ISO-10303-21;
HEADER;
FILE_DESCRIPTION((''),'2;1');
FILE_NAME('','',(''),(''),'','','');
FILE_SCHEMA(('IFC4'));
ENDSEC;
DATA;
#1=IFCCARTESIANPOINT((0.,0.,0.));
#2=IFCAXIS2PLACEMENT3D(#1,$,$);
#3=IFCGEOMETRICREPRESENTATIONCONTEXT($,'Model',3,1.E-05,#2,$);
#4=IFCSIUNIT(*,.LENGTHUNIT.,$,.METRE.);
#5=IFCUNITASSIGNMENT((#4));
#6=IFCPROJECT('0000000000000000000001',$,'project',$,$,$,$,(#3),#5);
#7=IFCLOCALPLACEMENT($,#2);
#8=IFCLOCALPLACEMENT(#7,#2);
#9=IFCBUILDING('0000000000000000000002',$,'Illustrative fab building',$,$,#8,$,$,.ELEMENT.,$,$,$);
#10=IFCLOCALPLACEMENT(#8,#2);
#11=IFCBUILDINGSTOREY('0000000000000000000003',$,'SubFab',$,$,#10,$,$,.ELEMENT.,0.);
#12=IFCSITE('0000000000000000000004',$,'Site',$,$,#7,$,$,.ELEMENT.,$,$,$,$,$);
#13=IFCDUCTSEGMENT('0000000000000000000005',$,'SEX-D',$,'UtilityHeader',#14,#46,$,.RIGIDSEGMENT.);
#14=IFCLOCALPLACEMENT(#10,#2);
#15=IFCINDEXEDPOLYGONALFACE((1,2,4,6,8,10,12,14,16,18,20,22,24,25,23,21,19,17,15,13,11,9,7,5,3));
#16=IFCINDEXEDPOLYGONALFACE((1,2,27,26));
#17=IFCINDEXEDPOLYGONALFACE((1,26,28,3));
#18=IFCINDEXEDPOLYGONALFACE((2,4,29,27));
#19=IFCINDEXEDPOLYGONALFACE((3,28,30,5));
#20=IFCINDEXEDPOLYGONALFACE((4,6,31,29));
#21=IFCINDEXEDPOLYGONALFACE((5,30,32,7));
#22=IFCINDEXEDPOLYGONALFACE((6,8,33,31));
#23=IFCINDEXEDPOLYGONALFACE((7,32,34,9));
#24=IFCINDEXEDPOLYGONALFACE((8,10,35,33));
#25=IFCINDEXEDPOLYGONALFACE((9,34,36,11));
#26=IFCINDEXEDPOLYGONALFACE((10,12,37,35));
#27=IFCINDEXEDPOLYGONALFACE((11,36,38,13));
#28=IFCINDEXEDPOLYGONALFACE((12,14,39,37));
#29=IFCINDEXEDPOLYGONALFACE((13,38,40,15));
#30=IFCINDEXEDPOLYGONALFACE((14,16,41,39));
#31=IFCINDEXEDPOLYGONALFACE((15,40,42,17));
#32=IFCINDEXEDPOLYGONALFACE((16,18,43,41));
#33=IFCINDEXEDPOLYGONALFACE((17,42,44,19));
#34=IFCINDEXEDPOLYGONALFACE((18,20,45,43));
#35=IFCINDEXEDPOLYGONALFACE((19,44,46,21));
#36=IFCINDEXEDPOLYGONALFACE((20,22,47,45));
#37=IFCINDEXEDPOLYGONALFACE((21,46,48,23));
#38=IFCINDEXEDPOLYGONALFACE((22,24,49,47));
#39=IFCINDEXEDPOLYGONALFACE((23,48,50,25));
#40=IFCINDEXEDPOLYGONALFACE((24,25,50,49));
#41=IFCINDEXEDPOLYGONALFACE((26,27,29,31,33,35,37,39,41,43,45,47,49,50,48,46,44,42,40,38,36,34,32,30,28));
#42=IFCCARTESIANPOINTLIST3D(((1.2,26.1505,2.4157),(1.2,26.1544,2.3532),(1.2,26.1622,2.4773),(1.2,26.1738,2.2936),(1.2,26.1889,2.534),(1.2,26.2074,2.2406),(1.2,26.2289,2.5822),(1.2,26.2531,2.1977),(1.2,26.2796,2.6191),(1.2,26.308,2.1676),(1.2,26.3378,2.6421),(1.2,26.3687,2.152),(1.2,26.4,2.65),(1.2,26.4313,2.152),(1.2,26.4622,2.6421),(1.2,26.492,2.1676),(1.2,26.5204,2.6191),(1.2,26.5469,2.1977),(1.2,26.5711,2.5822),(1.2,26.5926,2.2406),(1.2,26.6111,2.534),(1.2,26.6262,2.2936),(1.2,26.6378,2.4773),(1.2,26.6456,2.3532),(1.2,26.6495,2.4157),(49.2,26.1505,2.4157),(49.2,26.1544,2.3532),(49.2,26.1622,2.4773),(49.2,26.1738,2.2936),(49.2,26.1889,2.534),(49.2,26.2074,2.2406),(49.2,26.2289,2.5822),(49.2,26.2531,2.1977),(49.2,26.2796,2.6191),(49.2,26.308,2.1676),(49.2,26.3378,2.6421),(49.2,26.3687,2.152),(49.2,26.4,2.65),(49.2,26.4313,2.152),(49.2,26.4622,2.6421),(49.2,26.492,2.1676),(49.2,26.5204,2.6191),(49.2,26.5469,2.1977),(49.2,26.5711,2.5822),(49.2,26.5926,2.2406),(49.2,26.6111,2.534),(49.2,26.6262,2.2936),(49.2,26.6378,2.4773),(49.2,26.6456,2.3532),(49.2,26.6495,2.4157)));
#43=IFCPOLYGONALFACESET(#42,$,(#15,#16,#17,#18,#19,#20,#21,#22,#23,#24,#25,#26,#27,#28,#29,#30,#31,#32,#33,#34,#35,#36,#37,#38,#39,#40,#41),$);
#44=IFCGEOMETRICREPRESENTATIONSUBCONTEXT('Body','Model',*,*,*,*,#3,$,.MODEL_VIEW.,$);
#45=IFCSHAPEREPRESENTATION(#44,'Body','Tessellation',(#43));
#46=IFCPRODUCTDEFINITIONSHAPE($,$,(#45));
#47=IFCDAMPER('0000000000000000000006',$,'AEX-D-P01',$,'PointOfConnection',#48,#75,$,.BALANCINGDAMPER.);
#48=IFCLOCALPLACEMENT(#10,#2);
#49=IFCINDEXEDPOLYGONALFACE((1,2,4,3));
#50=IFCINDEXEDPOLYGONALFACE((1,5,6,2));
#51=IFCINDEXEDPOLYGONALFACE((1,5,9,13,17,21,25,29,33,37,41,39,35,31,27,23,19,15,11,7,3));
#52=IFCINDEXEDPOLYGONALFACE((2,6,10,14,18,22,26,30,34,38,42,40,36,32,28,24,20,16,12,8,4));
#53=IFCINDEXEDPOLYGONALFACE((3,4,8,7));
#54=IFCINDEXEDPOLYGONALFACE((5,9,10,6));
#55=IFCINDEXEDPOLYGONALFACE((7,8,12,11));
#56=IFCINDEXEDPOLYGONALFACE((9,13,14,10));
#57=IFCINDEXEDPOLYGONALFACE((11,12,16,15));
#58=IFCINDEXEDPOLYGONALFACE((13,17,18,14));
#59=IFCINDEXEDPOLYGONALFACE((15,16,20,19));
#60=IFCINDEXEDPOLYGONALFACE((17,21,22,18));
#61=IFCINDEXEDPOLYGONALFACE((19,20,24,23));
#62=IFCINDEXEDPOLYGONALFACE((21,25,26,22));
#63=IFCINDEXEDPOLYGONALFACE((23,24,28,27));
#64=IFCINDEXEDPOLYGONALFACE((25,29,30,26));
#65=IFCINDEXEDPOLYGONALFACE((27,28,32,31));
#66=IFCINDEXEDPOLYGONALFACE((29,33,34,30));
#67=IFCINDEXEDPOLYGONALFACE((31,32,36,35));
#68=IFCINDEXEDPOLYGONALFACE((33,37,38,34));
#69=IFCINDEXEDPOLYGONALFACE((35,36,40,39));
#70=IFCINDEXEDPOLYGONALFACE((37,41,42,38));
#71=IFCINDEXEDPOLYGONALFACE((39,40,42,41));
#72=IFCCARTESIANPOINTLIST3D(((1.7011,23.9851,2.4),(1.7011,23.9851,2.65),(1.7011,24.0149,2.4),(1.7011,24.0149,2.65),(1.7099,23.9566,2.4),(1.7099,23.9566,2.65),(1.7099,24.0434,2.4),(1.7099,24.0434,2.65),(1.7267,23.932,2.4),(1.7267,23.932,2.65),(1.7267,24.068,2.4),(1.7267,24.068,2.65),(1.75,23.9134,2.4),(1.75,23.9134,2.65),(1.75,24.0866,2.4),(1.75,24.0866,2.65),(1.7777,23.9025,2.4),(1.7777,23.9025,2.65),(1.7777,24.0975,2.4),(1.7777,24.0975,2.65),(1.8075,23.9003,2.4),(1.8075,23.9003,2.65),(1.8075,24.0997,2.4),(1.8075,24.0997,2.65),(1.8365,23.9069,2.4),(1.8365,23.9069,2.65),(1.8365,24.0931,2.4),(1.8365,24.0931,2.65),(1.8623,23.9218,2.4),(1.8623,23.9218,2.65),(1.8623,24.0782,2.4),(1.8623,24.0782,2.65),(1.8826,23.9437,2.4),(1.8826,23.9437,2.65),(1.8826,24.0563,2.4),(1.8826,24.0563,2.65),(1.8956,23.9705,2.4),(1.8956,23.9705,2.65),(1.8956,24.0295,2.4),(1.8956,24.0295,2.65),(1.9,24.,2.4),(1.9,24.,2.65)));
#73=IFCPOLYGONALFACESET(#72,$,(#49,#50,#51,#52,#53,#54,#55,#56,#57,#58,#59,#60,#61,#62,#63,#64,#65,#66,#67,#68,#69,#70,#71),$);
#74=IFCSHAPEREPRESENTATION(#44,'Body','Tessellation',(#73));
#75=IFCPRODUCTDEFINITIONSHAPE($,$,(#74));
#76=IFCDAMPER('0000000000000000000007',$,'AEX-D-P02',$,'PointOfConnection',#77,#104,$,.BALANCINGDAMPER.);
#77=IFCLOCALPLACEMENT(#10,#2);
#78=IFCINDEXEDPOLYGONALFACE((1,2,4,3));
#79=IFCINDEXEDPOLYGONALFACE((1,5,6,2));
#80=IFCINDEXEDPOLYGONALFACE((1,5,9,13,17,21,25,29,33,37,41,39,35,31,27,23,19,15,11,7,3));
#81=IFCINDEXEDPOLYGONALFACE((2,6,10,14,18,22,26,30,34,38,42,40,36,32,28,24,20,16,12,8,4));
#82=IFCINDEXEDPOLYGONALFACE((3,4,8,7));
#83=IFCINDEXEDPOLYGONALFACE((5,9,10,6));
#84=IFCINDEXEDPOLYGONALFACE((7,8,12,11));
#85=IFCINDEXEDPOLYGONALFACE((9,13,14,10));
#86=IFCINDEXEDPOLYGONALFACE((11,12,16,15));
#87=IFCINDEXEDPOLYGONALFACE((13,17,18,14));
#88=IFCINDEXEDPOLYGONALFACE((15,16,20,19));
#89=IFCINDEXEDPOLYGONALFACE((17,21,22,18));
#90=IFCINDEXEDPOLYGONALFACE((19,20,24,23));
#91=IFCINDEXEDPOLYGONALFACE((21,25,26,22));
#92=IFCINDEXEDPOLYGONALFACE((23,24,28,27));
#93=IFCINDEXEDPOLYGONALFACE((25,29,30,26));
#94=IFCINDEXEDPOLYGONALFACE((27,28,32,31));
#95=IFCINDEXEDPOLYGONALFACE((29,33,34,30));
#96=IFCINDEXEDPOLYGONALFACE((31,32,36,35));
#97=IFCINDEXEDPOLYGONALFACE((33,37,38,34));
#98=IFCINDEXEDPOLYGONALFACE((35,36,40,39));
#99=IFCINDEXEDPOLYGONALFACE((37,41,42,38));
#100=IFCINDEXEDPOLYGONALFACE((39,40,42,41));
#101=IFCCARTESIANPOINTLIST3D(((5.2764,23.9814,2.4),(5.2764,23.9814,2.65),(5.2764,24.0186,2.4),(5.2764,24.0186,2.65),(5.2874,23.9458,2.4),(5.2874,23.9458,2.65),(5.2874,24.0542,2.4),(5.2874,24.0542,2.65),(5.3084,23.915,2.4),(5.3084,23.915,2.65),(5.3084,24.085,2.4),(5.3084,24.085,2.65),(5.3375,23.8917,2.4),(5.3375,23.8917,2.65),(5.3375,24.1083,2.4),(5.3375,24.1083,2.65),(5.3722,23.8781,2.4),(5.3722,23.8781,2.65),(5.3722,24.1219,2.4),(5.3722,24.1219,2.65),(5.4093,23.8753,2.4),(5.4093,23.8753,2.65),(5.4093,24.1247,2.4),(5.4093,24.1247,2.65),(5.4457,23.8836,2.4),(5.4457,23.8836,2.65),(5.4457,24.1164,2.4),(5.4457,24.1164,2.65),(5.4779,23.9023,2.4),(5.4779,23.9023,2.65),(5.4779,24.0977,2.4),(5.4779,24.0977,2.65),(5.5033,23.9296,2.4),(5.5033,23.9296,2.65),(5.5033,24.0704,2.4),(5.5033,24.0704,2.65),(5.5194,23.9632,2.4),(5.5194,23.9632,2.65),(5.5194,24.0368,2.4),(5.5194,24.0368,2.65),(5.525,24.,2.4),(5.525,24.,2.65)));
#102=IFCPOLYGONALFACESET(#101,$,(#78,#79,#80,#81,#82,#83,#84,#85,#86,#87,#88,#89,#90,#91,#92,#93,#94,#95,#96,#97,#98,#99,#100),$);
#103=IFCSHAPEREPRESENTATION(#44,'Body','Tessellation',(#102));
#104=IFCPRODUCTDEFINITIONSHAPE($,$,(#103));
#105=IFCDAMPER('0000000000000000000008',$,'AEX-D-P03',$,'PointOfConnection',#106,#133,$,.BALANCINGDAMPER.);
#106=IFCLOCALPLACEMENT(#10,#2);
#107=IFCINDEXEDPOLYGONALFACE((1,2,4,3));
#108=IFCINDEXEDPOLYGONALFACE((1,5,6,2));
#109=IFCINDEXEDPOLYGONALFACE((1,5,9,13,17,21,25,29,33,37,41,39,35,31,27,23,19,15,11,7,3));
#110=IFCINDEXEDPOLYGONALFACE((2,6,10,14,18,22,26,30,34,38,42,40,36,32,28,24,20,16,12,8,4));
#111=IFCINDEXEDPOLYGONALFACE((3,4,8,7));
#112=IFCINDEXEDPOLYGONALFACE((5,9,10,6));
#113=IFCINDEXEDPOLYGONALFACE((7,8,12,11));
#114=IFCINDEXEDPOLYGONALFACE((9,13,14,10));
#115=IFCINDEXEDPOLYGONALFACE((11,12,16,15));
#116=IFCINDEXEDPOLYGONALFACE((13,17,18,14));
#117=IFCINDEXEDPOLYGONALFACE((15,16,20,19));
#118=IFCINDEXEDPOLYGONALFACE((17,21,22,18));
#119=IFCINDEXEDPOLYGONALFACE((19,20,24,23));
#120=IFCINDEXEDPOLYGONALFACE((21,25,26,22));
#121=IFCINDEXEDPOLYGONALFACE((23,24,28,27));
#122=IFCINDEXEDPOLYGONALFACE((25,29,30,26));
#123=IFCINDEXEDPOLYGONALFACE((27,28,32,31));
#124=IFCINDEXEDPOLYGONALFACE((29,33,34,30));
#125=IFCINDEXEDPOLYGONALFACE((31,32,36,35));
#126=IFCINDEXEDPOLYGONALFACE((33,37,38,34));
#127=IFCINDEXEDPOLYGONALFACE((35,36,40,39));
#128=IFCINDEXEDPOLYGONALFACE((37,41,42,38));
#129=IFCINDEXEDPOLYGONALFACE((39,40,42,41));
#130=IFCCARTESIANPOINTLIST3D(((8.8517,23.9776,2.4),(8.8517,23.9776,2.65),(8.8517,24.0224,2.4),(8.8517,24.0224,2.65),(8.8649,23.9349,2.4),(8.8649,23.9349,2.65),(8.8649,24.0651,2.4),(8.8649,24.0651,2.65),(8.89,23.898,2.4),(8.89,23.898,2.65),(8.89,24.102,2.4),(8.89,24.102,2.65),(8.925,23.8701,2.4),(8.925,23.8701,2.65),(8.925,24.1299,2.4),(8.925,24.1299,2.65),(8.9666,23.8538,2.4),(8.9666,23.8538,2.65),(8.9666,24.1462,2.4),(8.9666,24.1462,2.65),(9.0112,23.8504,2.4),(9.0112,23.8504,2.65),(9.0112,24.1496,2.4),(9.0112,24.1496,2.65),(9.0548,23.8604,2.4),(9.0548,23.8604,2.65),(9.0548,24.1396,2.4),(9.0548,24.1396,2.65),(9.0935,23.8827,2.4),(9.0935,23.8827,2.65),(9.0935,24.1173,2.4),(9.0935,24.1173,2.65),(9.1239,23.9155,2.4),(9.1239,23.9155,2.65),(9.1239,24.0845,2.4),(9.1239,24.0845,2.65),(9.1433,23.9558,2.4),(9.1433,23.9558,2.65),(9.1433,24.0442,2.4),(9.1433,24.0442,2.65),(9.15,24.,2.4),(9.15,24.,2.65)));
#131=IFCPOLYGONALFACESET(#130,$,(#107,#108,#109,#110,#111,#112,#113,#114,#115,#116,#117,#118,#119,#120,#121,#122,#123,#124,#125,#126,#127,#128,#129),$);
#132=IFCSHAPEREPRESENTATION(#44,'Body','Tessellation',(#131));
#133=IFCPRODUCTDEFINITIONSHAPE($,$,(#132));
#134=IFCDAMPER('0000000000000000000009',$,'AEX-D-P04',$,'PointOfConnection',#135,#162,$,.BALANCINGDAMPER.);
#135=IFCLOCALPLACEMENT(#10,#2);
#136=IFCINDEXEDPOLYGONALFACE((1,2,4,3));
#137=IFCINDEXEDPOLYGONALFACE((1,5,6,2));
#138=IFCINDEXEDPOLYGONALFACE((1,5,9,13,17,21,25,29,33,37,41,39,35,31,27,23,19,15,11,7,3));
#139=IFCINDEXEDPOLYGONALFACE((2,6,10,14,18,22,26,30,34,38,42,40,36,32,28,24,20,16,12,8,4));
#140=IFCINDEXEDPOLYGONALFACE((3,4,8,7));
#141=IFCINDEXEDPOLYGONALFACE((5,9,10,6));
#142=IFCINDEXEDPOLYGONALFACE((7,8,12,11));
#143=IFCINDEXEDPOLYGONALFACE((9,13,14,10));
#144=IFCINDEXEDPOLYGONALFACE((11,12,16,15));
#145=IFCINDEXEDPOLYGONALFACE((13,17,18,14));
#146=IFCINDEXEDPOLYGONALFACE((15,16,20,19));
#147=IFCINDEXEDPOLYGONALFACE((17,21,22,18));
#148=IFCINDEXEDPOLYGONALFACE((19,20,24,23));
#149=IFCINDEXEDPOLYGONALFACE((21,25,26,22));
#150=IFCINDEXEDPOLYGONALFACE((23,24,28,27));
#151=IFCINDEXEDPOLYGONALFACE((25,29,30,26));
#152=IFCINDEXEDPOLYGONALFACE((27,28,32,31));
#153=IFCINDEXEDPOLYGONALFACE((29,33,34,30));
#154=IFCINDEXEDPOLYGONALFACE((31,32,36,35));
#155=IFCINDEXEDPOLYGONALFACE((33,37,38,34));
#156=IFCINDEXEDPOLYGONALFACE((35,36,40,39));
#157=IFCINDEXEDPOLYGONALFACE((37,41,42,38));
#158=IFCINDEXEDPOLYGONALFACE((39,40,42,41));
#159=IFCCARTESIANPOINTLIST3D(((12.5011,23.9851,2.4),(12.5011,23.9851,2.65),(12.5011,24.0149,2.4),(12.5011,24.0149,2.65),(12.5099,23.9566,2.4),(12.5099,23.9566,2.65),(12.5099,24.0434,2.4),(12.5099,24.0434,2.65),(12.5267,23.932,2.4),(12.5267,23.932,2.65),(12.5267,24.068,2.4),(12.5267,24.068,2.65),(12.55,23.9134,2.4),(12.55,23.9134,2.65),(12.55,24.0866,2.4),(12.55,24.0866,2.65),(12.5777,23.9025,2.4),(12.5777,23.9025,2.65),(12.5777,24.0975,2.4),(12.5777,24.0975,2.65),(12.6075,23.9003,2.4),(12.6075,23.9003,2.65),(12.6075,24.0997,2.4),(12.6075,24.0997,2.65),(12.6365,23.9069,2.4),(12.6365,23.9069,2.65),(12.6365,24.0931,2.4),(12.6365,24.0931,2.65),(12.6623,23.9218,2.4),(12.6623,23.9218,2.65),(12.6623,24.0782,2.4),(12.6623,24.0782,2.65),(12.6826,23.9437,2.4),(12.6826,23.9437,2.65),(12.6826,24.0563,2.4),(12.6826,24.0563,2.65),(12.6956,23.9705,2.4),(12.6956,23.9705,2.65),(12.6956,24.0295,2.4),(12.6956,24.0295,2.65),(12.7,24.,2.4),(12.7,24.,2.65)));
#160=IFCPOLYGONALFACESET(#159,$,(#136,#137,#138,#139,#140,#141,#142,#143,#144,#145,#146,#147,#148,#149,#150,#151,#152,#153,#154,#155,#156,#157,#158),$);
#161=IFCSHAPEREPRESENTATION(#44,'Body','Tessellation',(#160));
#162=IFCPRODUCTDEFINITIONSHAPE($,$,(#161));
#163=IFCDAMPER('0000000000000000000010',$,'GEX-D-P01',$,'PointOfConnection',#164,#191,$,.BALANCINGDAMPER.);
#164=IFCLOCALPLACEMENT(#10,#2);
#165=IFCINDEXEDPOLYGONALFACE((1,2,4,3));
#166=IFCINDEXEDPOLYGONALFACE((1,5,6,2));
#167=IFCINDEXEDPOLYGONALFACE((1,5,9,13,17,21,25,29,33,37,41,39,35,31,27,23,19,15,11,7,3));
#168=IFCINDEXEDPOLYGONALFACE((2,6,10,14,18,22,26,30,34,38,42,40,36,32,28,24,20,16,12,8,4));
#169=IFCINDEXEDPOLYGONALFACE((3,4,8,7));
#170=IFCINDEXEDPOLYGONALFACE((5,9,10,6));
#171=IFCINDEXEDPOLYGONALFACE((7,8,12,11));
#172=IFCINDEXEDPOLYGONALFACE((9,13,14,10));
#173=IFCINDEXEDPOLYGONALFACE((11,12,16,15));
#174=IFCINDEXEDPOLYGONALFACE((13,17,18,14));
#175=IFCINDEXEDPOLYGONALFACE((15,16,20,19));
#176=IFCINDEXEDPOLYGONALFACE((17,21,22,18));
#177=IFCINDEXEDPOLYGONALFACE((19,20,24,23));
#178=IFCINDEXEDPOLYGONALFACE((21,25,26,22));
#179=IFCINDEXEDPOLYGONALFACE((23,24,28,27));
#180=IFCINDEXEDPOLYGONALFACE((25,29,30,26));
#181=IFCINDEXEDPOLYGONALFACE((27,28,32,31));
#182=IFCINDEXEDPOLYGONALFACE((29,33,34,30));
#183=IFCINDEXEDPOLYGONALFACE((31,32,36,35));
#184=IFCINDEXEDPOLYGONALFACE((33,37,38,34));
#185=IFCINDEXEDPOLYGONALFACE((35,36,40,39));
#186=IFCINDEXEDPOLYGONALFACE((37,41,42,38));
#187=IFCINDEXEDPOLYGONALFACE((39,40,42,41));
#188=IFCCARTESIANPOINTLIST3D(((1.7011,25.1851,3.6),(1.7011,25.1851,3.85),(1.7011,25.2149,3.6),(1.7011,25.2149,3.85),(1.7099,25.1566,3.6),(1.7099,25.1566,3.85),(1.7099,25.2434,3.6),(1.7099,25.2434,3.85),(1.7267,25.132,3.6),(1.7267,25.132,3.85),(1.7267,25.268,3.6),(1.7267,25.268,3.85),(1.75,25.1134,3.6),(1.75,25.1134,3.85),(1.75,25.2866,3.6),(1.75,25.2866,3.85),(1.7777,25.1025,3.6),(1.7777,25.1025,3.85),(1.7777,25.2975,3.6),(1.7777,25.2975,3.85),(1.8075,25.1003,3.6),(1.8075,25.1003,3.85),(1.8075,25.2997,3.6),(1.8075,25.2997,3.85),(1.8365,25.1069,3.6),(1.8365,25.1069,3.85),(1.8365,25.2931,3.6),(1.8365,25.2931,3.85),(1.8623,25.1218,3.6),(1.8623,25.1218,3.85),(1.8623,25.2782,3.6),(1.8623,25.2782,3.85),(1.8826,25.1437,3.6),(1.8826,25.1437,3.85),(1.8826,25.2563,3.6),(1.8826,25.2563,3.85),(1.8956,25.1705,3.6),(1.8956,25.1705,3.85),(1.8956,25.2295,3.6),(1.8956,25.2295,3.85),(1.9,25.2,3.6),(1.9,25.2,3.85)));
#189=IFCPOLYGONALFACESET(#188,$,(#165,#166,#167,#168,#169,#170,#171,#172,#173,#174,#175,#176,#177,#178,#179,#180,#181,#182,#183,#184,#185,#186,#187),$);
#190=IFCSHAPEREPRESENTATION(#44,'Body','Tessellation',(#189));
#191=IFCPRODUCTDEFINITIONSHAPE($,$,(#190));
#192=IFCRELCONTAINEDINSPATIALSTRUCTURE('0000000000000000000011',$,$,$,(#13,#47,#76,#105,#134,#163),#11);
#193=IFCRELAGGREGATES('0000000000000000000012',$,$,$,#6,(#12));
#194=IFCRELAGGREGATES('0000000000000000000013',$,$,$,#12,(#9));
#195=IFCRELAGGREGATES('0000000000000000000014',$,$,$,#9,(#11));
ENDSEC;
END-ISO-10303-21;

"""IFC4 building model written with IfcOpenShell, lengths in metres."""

from ifc_helpers import new_model, entity, si_unit, frame, origin, place, context, subcontext, project, spatial, element, save


model = new_model("IFC4")

# Units and contexts
model_context = context("Model", 3, precision=1e-05, world=origin())
body_context = subcontext(model_context, "Body", "Model", "MODEL_VIEW")
ifc_project = project(units=[si_unit("LENGTHUNIT", "METRE")], contexts=[model_context])

# Site, building, storey
site_placement = place(None, origin())
site = spatial("IfcSite", under=ifc_project, at=site_placement, Name="Site", CompositionType="ELEMENT")
building_placement = place(site_placement, origin())
building = spatial("IfcBuilding", under=site, at=building_placement, Name="Illustrative fab building", CompositionType="ELEMENT")
storey_placement = place(building_placement, origin())
storey = spatial("IfcBuildingStorey", under=building, at=storey_placement, Name="SubFab", CompositionType="ELEMENT", Elevation=0.0)

# Duct segment
duct_segment_1_placement = place(storey_placement, frame((1.2, 26.4, 2.4)))
element("IfcDuctSegment", 1, at=duct_segment_1_placement, inside=storey, Name="SEX-D", ObjectType="UtilityHeader", PredefinedType="RIGIDSEGMENT", context=body_context, shape_type="AdvancedSweptSolid", body=[
    entity("IfcSweptDiskSolid", entity("IfcPolyline", [entity("IfcCartesianPoint", [0.0, 0.0, 0.0]), entity("IfcCartesianPoint", [48.0, 0.0, 0.0])]), 0.25),
])

# Dampers
damper_1_placement = place(storey_placement, frame((1.8, 24.0, 2.4)))
element("IfcDamper", 2, at=damper_1_placement, inside=storey, Name="AEX-D-P01", ObjectType="PointOfConnection", PredefinedType="BALANCINGDAMPER", context=body_context, shape_type="AdvancedSweptSolid", body=[
    entity("IfcSweptDiskSolid", entity("IfcPolyline", [entity("IfcCartesianPoint", [0.0, 0.0, 0.0]), entity("IfcCartesianPoint", [0.0, 0.0, 0.25])]), 0.1),
])
damper_2_placement = place(storey_placement, frame((5.4, 24.0, 2.4)))
element("IfcDamper", 3, at=damper_2_placement, inside=storey, Name="AEX-D-P02", ObjectType="PointOfConnection", PredefinedType="BALANCINGDAMPER", context=body_context, shape_type="AdvancedSweptSolid", body=[
    entity("IfcSweptDiskSolid", entity("IfcPolyline", [entity("IfcCartesianPoint", [0.0, 0.0, 0.0]), entity("IfcCartesianPoint", [0.0, 0.0, 0.25])]), 0.125),
])
damper_3_placement = place(storey_placement, frame((9.0, 24.0, 2.4)))
element("IfcDamper", 4, at=damper_3_placement, inside=storey, Name="AEX-D-P03", ObjectType="PointOfConnection", PredefinedType="BALANCINGDAMPER", context=body_context, shape_type="AdvancedSweptSolid", body=[
    entity("IfcSweptDiskSolid", entity("IfcPolyline", [entity("IfcCartesianPoint", [0.0, 0.0, 0.0]), entity("IfcCartesianPoint", [0.0, 0.0, 0.25])]), 0.15),
])
for number, where, name in (
    (5, (12.6, 24.0, 2.4), "AEX-D-P04"),
    (6, (1.8, 25.2, 3.6), "GEX-D-P01"),
):
    element("IfcDamper", number, at=place(storey_placement, frame(where)), inside=storey, Name=name, ObjectType="PointOfConnection", PredefinedType="BALANCINGDAMPER", context=body_context, shape_type="AdvancedSweptSolid", body=[
        entity("IfcSweptDiskSolid", entity("IfcPolyline", [entity("IfcCartesianPoint", [0.0, 0.0, 0.0]), entity("IfcCartesianPoint", [0.0, 0.0, 0.25])]), 0.1),
    ])

save(model, "model.ifc")
